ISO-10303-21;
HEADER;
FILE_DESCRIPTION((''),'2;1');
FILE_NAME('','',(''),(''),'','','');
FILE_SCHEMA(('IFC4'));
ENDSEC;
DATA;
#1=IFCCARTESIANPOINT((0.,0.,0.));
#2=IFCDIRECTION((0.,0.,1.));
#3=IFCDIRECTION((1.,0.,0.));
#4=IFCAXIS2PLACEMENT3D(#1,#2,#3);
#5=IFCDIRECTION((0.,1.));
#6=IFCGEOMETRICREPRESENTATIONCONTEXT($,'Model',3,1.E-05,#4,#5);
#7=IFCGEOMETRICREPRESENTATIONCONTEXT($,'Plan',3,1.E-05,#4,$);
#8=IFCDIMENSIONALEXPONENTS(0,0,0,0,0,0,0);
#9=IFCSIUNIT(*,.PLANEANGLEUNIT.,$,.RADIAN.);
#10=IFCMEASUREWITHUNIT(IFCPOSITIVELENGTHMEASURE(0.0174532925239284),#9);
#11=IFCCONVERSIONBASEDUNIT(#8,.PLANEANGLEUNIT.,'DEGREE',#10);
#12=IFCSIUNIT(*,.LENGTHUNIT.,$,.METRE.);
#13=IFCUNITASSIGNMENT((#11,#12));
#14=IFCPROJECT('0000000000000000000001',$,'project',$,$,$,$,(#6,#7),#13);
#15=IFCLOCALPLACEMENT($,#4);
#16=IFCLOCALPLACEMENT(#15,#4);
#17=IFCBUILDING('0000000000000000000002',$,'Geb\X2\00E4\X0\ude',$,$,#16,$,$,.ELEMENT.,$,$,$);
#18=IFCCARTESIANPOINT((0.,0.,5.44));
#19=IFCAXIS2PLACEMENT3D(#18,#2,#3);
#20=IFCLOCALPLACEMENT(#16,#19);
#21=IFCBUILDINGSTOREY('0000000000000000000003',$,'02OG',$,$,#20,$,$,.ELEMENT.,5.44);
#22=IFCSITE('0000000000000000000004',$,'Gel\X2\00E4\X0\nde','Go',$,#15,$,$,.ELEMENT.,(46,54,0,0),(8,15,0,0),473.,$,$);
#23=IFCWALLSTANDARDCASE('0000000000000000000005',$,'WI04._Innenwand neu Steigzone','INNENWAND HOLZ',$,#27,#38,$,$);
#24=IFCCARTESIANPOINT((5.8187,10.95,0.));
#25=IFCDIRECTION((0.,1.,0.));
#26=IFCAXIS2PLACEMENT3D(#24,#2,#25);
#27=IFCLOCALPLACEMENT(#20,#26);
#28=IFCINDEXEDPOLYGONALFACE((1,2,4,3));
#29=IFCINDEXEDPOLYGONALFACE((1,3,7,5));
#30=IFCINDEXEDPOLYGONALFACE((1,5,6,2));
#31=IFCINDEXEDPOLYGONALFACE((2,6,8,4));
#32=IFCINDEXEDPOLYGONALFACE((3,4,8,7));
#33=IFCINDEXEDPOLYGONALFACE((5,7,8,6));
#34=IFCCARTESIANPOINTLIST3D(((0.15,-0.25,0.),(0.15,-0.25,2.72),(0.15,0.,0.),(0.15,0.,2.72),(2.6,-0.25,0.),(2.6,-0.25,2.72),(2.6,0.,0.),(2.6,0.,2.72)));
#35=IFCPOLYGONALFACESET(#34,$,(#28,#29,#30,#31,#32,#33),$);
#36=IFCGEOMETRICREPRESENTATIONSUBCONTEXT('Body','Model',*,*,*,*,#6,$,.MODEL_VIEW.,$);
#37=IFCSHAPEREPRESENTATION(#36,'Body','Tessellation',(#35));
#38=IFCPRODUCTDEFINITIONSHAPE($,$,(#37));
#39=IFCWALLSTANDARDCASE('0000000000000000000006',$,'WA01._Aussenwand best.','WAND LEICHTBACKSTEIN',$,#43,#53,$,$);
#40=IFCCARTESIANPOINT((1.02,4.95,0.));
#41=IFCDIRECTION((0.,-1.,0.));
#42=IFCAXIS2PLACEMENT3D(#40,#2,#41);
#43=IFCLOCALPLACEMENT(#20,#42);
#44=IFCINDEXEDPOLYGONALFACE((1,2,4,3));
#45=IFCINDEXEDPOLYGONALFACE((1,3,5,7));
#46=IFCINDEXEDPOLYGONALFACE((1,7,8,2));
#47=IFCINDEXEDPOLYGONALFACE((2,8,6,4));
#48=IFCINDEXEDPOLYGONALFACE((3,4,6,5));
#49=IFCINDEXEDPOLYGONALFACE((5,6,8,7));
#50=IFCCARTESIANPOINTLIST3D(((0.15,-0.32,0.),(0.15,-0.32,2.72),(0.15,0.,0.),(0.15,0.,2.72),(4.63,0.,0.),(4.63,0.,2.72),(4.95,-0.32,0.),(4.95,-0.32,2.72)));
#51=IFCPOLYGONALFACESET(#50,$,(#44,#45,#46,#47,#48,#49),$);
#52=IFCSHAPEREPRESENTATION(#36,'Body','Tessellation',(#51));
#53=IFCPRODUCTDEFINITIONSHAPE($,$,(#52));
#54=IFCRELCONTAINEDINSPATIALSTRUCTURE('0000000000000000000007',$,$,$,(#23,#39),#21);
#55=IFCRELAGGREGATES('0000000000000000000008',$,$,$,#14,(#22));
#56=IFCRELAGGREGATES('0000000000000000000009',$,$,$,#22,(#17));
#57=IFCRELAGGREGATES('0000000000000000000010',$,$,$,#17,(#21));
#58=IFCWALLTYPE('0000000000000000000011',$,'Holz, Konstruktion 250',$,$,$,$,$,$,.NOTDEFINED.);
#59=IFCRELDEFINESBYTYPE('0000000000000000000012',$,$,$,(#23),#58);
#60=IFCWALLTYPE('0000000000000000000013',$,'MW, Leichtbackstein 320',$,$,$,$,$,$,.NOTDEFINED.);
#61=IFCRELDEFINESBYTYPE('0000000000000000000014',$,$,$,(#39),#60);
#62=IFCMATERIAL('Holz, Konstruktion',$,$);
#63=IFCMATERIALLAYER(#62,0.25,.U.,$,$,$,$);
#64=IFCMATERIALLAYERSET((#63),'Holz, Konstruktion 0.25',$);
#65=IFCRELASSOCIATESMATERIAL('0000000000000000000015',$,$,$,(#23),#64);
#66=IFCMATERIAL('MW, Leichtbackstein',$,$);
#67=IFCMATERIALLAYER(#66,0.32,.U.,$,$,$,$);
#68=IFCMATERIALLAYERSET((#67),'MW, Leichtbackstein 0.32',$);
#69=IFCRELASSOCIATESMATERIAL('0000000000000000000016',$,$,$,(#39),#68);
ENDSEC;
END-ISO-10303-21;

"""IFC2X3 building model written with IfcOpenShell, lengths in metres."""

from ifc_helpers import new_model, entity, si_unit, converted_unit, direction, frame, origin_with_axes, place, context, subcontext, project, spatial, polyline, outline, extrude, material, layer, layer_set, layer_usage, type_object, element, save


model = new_model("IFC2X3")

# Units and contexts
model_context = context("Model", 3, precision=1e-05, world=origin_with_axes(), true_north=direction((0.0, 1.0)))
plan_context = context("Plan", 3, precision=1e-05, world=origin_with_axes())
body_context = subcontext(model_context, "Body", "Model", "MODEL_VIEW")
ifc_project = project(units=[converted_unit("PLANEANGLEUNIT", "DEGREE", entity("IfcPositiveLengthMeasure", 0.0174532925239284), si_unit("PLANEANGLEUNIT", "RADIAN"), dimensions=[0, 0, 0, 0, 0, 0, 0]), si_unit("LENGTHUNIT", "METRE")], contexts=[model_context, plan_context])

# Site, building, storey
site_placement = place(None, origin_with_axes())
site = spatial("IfcSite", under=ifc_project, at=site_placement, Name="Gelände", Description="Go", CompositionType="ELEMENT", RefLatitude=(46, 54, 0, 0), RefLongitude=(8, 15, 0, 0), RefElevation=473.0)
building_placement = place(site_placement, origin_with_axes())
building = spatial("IfcBuilding", under=site, at=building_placement, Name="Gebäude", CompositionType="ELEMENT")
storey_placement = place(building_placement, frame((0.0, 0.0, 5.44), z_axis=(0.0, 0.0, 1.0), x_axis=(1.0, 0.0, 0.0)))
storey = spatial("IfcBuildingStorey", under=building, at=storey_placement, Name="02OG", CompositionType="ELEMENT", Elevation=5.44)

# Shared definitions
ifc_material_1 = material(Name="Holz, Konstruktion")

# Walls
ifc_layer_1 = layer(ifc_material_1, 0.25, ventilated="UNKNOWN")
ifc_layer_set_1 = layer_set([ifc_layer_1], Name="Holz, Konstruktion 0.25")
ifc_layer_usage_1 = layer_usage(ifc_layer_set_1, "AXIS2", "NEGATIVE", 0.0)
wall_type_1 = type_object("IfcWallType", Name="Holz, Konstruktion 250", PredefinedType="NOTDEFINED")
wall_1_placement = place(storey_placement, frame((5.8187, 10.95, 0.0), z_axis=(0.0, 0.0, 1.0), x_axis=(0.0, 1.0, 0.0)))
element("IfcWallStandardCase", 1, at=wall_1_placement, inside=storey, type_object=wall_type_1, material=ifc_layer_usage_1, Name="WI04._Innenwand neu Steigzone", Description="INNENWAND HOLZ", context=body_context, shape_type="SweptSolid", body=[
    extrude(outline(polyline([(0.15, -0.25), (2.6, -0.25), (2.6, 0.0), (0.15, 0.0), (0.15, -0.25)])), origin_with_axes(), (0.0, 0.0, 1.0), 2.72),
])
ifc_material_2 = material(Name="MW, Leichtbackstein")
ifc_layer_2 = layer(ifc_material_2, 0.32, ventilated="UNKNOWN")
ifc_layer_set_2 = layer_set([ifc_layer_2], Name="MW, Leichtbackstein 0.32")
ifc_layer_usage_2 = layer_usage(ifc_layer_set_2, "AXIS2", "POSITIVE", -0.32)
wall_type_2 = type_object("IfcWallType", Name="MW, Leichtbackstein 320", PredefinedType="NOTDEFINED")
wall_2_placement = place(storey_placement, frame((1.02, 4.95, 0.0), z_axis=(0.0, 0.0, 1.0), x_axis=(0.0, -1.0, 0.0)))
element("IfcWallStandardCase", 2, at=wall_2_placement, inside=storey, type_object=wall_type_2, material=ifc_layer_usage_2, Name="WA01._Aussenwand best.", Description="WAND LEICHTBACKSTEIN", context=body_context, shape_type="SweptSolid", body=[
    extrude(outline(polyline([(0.15, -0.32), (4.95, -0.32), (4.63, 0.0), (0.15, 0.0), (0.15, -0.32)])), origin_with_axes(), (0.0, 0.0, 1.0), 2.72),
])

save(model, "model.ifc")
